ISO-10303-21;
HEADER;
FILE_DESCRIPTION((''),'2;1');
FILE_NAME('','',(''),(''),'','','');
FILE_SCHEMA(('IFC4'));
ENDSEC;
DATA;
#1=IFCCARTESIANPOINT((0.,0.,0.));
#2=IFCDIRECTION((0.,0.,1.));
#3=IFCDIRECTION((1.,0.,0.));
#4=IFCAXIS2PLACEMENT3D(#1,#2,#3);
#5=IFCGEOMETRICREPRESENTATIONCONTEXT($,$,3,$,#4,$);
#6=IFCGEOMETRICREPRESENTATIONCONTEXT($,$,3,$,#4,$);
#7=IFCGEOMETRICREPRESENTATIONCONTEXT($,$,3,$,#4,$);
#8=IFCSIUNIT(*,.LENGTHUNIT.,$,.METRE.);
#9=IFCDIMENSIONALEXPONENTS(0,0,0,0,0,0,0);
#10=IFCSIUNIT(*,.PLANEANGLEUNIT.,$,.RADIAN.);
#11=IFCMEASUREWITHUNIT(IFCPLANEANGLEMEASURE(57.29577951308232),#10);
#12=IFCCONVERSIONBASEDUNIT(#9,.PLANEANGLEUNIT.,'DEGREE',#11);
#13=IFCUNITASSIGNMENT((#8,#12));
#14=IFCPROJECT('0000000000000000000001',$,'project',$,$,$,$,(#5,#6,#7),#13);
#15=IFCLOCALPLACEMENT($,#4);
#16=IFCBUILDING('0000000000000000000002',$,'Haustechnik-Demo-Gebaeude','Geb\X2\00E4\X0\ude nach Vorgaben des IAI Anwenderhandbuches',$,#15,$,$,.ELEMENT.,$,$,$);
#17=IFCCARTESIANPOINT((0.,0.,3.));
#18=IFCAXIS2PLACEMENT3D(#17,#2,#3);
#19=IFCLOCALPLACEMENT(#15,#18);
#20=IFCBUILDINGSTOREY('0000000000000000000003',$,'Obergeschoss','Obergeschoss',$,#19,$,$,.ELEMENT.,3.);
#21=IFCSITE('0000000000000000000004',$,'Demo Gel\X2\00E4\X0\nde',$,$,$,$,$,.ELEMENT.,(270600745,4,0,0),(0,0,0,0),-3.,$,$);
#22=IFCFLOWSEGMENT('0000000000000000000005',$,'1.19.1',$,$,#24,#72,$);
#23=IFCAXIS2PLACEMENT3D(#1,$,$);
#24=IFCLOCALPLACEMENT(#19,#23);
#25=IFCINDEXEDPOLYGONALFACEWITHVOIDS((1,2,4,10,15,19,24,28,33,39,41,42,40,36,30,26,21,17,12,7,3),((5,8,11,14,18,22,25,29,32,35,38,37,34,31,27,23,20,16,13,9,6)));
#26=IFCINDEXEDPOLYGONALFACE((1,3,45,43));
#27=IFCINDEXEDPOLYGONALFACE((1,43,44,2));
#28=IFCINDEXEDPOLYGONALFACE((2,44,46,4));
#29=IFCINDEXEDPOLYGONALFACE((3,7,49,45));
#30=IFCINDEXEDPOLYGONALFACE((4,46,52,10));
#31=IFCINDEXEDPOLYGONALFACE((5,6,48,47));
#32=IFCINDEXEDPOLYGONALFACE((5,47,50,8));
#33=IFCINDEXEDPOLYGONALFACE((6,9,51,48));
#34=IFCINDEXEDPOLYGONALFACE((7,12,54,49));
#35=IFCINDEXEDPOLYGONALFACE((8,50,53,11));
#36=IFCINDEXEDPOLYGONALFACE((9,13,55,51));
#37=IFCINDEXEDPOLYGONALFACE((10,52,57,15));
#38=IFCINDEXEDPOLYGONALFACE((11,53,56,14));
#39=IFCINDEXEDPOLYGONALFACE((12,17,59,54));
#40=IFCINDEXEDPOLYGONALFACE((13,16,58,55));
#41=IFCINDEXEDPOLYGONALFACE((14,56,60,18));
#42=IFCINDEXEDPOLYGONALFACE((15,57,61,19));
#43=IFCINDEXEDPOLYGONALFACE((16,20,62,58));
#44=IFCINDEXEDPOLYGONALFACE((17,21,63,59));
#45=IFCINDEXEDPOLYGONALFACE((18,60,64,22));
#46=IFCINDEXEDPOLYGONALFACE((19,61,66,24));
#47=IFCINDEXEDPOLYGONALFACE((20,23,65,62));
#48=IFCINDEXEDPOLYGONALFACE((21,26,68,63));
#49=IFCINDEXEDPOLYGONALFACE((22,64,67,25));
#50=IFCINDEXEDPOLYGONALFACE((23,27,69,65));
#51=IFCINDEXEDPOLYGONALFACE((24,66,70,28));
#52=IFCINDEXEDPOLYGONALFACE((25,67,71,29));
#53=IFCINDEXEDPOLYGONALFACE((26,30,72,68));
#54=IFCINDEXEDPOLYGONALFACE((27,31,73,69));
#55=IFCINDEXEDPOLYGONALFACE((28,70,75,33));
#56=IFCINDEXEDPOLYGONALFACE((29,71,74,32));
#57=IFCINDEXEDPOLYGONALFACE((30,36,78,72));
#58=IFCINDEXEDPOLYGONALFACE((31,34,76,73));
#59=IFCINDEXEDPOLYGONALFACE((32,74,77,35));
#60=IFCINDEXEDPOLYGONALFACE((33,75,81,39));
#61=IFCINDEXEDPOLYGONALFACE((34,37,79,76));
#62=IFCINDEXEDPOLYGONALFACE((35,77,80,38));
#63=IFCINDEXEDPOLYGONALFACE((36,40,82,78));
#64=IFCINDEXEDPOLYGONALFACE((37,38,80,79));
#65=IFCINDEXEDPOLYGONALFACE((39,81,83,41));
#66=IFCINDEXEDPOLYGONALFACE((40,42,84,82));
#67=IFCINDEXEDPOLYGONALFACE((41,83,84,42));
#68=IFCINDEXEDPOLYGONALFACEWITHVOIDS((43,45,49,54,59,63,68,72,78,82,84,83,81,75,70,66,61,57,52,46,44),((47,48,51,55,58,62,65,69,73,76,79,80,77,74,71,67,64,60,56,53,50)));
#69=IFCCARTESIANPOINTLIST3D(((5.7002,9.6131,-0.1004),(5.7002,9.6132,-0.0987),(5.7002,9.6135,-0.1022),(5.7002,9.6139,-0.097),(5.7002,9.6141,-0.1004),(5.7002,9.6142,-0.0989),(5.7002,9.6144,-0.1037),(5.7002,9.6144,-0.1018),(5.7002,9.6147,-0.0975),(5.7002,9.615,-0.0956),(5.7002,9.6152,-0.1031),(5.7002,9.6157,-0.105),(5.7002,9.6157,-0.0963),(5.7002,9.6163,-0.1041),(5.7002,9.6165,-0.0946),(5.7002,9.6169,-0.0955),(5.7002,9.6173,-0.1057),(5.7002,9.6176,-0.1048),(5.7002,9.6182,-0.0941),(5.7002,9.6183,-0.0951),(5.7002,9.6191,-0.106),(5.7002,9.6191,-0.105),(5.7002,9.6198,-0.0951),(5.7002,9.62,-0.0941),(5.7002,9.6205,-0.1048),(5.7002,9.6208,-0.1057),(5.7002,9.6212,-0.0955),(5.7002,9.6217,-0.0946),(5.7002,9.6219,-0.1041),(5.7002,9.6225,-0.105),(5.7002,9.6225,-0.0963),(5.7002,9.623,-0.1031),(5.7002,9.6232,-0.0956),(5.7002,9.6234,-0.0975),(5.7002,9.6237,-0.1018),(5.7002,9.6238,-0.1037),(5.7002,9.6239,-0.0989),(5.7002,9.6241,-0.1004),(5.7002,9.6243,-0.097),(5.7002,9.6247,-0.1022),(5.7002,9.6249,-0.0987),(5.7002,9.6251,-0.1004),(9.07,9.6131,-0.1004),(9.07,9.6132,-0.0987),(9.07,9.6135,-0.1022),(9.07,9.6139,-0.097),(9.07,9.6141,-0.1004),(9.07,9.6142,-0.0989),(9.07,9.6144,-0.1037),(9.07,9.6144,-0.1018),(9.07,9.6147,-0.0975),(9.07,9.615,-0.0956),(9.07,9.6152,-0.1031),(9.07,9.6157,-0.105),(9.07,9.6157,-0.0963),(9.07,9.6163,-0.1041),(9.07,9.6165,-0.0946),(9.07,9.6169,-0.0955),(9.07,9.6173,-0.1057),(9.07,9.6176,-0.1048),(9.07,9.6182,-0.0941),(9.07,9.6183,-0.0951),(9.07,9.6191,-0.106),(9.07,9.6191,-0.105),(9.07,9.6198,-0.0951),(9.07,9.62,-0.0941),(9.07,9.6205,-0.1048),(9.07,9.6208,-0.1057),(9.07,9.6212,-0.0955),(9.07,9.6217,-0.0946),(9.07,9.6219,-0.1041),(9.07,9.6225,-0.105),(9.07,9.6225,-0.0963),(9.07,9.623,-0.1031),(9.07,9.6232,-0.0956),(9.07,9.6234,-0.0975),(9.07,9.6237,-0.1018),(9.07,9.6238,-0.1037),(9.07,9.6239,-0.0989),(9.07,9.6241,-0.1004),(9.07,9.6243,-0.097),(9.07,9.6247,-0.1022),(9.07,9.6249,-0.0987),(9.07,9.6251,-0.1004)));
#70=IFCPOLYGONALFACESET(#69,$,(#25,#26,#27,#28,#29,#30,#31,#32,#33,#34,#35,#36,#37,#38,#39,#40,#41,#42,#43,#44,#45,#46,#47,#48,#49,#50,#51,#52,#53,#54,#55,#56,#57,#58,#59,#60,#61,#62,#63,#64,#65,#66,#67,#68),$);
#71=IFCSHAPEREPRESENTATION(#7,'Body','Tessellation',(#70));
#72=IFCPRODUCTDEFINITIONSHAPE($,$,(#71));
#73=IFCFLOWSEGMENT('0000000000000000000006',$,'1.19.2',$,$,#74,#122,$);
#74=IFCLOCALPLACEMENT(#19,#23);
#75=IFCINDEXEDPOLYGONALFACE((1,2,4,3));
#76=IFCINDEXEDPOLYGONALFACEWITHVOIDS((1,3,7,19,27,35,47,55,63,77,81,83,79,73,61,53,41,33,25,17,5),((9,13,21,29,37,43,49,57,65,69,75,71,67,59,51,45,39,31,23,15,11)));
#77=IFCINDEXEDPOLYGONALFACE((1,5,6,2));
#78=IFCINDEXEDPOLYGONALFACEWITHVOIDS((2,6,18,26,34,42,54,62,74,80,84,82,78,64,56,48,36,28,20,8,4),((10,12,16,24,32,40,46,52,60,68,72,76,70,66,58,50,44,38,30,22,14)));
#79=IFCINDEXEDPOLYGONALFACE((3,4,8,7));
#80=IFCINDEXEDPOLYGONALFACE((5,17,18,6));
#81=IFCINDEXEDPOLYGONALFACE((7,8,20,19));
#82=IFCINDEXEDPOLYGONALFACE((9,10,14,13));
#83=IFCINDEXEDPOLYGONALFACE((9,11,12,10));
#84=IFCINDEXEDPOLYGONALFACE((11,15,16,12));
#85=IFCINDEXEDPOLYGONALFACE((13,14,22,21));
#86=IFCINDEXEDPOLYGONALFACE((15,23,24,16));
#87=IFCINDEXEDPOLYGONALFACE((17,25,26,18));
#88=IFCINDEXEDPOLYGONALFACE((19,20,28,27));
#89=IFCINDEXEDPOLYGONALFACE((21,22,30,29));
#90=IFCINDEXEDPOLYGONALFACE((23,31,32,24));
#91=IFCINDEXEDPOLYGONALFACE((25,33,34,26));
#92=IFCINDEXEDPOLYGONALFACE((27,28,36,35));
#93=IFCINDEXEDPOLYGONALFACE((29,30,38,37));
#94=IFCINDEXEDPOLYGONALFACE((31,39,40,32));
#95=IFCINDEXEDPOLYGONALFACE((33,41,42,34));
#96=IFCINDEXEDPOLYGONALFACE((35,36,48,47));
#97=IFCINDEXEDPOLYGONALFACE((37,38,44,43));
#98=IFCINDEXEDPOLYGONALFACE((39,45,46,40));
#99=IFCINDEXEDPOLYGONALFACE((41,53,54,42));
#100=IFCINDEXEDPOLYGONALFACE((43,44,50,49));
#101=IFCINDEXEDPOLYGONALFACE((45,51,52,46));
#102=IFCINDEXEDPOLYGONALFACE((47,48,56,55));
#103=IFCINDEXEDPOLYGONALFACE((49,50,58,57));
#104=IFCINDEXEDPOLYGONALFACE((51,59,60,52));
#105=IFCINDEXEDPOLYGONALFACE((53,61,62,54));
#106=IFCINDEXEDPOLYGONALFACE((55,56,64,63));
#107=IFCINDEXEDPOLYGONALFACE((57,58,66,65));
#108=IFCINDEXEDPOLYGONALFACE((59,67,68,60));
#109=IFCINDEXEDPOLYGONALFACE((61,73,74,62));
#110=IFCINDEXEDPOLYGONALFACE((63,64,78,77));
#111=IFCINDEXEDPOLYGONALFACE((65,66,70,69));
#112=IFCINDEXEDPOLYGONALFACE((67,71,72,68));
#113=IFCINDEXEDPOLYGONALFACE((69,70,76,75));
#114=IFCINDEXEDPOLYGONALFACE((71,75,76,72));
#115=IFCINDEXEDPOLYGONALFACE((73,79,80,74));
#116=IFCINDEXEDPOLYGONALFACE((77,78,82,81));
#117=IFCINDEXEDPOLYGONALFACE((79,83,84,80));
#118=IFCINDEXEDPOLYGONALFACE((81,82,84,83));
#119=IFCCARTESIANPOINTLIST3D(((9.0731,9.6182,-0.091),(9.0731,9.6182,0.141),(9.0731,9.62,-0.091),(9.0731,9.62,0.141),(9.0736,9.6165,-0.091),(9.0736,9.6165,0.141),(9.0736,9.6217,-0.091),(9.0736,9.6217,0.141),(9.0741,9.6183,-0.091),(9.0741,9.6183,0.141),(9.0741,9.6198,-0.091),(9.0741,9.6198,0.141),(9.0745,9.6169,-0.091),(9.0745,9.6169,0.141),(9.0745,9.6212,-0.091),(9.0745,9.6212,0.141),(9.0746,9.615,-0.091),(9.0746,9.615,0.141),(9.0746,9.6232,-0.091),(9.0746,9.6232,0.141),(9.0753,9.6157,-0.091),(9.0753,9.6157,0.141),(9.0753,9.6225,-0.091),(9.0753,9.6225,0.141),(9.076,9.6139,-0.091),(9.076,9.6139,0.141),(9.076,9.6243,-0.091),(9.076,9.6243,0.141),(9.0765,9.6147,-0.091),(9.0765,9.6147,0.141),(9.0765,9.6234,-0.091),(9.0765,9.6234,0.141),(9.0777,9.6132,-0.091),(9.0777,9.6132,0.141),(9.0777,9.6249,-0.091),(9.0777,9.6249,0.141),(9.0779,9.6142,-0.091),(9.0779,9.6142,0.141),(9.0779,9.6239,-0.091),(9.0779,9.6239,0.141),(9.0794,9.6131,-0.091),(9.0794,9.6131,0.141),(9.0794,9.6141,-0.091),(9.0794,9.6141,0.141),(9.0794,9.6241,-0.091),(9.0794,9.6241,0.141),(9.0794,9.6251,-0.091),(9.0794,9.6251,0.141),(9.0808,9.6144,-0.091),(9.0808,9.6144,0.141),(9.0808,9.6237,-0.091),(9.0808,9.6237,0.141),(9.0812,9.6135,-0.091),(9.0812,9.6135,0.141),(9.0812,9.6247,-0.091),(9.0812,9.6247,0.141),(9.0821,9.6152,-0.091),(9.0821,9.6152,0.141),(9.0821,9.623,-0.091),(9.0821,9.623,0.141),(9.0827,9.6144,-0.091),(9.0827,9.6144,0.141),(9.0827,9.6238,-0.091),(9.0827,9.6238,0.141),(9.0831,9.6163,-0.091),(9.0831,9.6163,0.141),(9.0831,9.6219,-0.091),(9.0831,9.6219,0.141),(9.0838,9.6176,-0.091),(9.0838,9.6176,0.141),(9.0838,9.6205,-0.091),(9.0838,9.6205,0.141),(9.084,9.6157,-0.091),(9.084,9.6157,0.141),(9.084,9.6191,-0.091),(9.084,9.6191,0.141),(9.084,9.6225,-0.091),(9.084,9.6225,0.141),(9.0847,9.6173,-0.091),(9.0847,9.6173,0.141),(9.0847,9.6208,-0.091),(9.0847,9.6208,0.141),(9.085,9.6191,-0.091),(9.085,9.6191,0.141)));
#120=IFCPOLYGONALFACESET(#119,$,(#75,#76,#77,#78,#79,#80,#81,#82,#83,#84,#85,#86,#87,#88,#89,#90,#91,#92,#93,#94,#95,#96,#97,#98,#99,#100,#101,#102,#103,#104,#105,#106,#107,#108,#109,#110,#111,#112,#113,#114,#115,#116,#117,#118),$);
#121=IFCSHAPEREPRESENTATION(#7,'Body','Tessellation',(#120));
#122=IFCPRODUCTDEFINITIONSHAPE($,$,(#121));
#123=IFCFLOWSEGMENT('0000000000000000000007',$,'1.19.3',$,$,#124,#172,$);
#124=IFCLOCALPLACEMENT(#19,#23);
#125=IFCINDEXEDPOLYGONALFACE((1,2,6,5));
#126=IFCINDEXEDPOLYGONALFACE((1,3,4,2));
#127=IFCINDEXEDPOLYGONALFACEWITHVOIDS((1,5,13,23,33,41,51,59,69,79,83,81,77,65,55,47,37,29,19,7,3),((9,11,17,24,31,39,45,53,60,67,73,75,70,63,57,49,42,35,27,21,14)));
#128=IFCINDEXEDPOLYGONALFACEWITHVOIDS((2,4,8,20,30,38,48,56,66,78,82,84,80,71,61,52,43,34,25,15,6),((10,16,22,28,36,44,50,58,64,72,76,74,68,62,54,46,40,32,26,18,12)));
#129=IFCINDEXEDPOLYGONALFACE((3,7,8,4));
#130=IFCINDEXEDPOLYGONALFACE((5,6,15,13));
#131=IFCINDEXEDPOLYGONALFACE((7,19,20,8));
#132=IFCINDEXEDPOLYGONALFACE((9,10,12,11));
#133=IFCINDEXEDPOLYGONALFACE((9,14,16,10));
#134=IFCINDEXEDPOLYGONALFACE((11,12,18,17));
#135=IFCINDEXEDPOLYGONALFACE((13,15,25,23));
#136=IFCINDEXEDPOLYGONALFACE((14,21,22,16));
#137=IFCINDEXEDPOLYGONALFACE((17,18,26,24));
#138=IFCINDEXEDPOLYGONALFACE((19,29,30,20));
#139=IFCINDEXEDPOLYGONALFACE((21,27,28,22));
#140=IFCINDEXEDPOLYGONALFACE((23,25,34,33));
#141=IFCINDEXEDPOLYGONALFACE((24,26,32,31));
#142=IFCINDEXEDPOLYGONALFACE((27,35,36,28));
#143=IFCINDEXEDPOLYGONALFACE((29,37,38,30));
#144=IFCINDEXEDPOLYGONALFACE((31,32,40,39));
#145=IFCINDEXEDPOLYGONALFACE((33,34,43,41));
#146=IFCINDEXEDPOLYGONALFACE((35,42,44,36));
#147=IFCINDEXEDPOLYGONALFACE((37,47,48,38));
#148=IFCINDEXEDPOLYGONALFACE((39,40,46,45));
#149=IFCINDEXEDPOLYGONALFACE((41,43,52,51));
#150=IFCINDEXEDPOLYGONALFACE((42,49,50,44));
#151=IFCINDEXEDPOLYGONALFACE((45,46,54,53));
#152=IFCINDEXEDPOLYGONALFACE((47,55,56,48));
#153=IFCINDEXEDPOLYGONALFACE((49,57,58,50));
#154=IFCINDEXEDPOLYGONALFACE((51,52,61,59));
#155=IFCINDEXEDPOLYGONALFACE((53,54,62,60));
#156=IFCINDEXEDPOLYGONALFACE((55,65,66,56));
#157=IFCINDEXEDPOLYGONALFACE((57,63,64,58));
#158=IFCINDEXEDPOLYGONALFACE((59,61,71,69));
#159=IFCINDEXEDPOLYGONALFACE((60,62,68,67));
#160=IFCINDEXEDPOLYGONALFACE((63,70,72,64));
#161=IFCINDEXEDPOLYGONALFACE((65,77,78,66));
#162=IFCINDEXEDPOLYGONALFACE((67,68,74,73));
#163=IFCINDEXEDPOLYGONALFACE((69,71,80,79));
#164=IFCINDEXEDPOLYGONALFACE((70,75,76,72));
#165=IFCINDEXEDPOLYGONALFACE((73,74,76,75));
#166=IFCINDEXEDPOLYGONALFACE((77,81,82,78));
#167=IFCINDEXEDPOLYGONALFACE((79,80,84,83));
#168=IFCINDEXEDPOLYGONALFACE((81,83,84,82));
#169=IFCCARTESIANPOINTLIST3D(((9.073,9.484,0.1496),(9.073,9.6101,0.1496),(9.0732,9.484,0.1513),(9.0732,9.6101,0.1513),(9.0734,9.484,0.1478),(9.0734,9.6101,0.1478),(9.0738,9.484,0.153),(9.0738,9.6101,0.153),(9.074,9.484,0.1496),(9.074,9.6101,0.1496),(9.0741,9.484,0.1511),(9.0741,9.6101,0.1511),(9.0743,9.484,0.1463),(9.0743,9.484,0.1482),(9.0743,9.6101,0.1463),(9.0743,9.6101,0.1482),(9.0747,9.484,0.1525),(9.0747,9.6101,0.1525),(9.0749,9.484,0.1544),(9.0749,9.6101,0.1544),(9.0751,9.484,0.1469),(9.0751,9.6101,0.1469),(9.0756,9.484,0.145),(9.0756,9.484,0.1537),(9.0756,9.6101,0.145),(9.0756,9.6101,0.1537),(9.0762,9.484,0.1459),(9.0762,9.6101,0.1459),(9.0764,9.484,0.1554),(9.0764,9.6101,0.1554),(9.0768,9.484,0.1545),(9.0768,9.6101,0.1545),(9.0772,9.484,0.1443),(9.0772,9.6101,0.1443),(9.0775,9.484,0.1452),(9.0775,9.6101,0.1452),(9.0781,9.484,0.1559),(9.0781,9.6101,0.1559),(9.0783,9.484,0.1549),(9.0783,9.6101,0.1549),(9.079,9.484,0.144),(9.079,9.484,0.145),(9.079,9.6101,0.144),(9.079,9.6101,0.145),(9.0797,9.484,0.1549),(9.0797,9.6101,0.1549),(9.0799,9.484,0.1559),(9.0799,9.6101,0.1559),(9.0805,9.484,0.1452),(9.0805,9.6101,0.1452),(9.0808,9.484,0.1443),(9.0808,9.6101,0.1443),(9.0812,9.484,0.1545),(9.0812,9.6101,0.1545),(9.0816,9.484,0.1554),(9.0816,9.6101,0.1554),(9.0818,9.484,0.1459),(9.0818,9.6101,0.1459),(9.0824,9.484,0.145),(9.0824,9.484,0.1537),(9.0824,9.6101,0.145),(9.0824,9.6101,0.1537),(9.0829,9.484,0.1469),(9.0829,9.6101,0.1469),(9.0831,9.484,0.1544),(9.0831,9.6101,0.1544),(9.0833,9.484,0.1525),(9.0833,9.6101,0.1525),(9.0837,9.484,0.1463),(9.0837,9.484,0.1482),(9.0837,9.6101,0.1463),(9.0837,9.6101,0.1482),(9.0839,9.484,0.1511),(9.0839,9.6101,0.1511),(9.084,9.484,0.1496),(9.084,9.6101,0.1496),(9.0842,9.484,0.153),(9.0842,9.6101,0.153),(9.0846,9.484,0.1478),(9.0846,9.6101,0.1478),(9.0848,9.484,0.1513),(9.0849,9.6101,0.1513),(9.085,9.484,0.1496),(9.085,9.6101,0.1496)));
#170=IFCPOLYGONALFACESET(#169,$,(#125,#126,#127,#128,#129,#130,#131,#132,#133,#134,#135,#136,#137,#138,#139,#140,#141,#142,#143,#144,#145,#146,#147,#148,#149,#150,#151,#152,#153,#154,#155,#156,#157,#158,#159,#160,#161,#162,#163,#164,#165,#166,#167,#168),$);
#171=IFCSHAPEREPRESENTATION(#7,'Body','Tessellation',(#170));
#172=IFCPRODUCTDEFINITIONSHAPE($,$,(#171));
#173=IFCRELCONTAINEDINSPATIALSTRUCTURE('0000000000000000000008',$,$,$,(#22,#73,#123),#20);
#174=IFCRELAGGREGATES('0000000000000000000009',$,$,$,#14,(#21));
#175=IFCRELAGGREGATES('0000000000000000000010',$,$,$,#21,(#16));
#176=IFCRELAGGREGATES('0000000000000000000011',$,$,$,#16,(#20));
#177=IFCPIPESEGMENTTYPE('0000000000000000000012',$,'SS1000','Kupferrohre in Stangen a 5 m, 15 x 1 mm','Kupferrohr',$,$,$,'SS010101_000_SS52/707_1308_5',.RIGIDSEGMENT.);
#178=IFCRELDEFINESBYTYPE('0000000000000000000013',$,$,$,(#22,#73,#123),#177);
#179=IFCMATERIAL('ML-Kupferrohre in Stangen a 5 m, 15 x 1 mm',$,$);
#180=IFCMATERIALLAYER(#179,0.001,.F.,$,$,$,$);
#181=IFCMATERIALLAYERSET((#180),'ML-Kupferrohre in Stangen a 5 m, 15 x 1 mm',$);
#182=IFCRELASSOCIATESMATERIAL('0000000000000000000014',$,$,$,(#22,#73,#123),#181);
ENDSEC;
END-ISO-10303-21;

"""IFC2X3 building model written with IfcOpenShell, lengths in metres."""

from ifc_helpers import new_model, entity, si_unit, converted_unit, frame, origin_with_axes, origin_2d_with_axis, place, context, project, spatial, hollow_circle, extrude, material, layer, layer_set, layer_usage, type_object, element, save


model = new_model("IFC2X3")

# Units and contexts
context_of_model_1 = context(None, 3, world=origin_with_axes())
context_of_model_2 = context(None, 3, world=origin_with_axes())
context_of_model_3 = context(None, 3, world=origin_with_axes())
ifc_project = project(units=[si_unit("LENGTHUNIT", "METRE"), converted_unit("PLANEANGLEUNIT", "DEGREE", entity("IfcPlaneAngleMeasure", 57.29577951308232), si_unit("PLANEANGLEUNIT", "RADIAN"), dimensions=[0, 0, 0, 0, 0, 0, 0])], contexts=[context_of_model_1, context_of_model_2, context_of_model_3])

# Site, building, storey
site = spatial("IfcSite", under=ifc_project, Name="Demo Gelände", CompositionType="ELEMENT", RefLatitude=(270600745, 4, 0, 0), RefLongitude=(0, 0, 0, 0), RefElevation=-3.0)
building_placement = place(None, origin_with_axes())
building = spatial("IfcBuilding", under=site, at=building_placement, Name="Haustechnik-Demo-Gebaeude", Description="Gebäude nach Vorgaben des IAI Anwenderhandbuches", CompositionType="ELEMENT")
storey_placement = place(building_placement, frame((0.0, 0.0, 3.0), z_axis=(0.0, 0.0, 1.0), x_axis=(1.0, 0.0, 0.0)))
storey = spatial("IfcBuildingStorey", under=building, at=storey_placement, Name="Obergeschoss", Description="Obergeschoss", CompositionType="ELEMENT", Elevation=3.0)

# Flow segments
ifc_material_1 = material(Name="ML-Kupferrohre in Stangen a 5 m, 15 x 1 mm")
ifc_layer_1 = layer(ifc_material_1, 0.001, ventilated=False)
ifc_layer_set_1 = layer_set([ifc_layer_1], Name="ML-Kupferrohre in Stangen a 5 m, 15 x 1 mm")
ifc_layer_usage_1 = layer_usage(ifc_layer_set_1, "AXIS2", "POSITIVE", 0.0)
pipe_segment_type_1 = type_object("IfcPipeSegmentType", Name="SS1000", Description="Kupferrohre in Stangen a 5 m, 15 x 1 mm", ApplicableOccurrence="Kupferrohr", ElementType="SS010101_000_SS52/707_1308_5", PredefinedType="RIGIDSEGMENT")
flow_segment_1_placement = place(storey_placement, frame((5.7002, 9.6191, -0.1), z_axis=(1.0, 0.0, 0.0), x_axis=(0.0, 0.0, -1.0)))
element("IfcFlowSegment", 1, at=flow_segment_1_placement, inside=storey, type_object=pipe_segment_type_1, material=ifc_layer_usage_1, Name="1.19.1", context=context_of_model_3, shape_type="SweptSolid", body=[
    extrude(hollow_circle(Radius=0.006, WallThickness=0.001, at=origin_2d_with_axis()), origin_with_axes(), (0.0, 0.0, 1.0), 3.3698),
])
flow_segment_2_placement = place(storey_placement, frame((9.079, 9.6191, -0.091), z_axis=(0.0, 0.0, 1.0), x_axis=(1.0, 0.0, 0.0)))
element("IfcFlowSegment", 2, at=flow_segment_2_placement, inside=storey, type_object=pipe_segment_type_1, material=ifc_layer_usage_1, Name="1.19.2", context=context_of_model_3, shape_type="SweptSolid", body=[
    extrude(hollow_circle(Radius=0.006, WallThickness=0.001, at=origin_2d_with_axis()), origin_with_axes(), (0.0, 0.0, 1.0), 0.232),
])
flow_segment_3_placement = place(storey_placement, frame((9.079, 9.6101, 0.15), z_axis=(-0.000002, -1.0, 0.0), x_axis=(0.0, 0.0, -1.0)))
element("IfcFlowSegment", 3, at=flow_segment_3_placement, inside=storey, type_object=pipe_segment_type_1, material=ifc_layer_usage_1, Name="1.19.3", context=context_of_model_3, shape_type="SweptSolid", body=[
    extrude(hollow_circle(Radius=0.006, WallThickness=0.001, at=origin_2d_with_axis()), origin_with_axes(), (0.0, 0.0, 1.0), 0.1261),
])

save(model, "model.ifc")
